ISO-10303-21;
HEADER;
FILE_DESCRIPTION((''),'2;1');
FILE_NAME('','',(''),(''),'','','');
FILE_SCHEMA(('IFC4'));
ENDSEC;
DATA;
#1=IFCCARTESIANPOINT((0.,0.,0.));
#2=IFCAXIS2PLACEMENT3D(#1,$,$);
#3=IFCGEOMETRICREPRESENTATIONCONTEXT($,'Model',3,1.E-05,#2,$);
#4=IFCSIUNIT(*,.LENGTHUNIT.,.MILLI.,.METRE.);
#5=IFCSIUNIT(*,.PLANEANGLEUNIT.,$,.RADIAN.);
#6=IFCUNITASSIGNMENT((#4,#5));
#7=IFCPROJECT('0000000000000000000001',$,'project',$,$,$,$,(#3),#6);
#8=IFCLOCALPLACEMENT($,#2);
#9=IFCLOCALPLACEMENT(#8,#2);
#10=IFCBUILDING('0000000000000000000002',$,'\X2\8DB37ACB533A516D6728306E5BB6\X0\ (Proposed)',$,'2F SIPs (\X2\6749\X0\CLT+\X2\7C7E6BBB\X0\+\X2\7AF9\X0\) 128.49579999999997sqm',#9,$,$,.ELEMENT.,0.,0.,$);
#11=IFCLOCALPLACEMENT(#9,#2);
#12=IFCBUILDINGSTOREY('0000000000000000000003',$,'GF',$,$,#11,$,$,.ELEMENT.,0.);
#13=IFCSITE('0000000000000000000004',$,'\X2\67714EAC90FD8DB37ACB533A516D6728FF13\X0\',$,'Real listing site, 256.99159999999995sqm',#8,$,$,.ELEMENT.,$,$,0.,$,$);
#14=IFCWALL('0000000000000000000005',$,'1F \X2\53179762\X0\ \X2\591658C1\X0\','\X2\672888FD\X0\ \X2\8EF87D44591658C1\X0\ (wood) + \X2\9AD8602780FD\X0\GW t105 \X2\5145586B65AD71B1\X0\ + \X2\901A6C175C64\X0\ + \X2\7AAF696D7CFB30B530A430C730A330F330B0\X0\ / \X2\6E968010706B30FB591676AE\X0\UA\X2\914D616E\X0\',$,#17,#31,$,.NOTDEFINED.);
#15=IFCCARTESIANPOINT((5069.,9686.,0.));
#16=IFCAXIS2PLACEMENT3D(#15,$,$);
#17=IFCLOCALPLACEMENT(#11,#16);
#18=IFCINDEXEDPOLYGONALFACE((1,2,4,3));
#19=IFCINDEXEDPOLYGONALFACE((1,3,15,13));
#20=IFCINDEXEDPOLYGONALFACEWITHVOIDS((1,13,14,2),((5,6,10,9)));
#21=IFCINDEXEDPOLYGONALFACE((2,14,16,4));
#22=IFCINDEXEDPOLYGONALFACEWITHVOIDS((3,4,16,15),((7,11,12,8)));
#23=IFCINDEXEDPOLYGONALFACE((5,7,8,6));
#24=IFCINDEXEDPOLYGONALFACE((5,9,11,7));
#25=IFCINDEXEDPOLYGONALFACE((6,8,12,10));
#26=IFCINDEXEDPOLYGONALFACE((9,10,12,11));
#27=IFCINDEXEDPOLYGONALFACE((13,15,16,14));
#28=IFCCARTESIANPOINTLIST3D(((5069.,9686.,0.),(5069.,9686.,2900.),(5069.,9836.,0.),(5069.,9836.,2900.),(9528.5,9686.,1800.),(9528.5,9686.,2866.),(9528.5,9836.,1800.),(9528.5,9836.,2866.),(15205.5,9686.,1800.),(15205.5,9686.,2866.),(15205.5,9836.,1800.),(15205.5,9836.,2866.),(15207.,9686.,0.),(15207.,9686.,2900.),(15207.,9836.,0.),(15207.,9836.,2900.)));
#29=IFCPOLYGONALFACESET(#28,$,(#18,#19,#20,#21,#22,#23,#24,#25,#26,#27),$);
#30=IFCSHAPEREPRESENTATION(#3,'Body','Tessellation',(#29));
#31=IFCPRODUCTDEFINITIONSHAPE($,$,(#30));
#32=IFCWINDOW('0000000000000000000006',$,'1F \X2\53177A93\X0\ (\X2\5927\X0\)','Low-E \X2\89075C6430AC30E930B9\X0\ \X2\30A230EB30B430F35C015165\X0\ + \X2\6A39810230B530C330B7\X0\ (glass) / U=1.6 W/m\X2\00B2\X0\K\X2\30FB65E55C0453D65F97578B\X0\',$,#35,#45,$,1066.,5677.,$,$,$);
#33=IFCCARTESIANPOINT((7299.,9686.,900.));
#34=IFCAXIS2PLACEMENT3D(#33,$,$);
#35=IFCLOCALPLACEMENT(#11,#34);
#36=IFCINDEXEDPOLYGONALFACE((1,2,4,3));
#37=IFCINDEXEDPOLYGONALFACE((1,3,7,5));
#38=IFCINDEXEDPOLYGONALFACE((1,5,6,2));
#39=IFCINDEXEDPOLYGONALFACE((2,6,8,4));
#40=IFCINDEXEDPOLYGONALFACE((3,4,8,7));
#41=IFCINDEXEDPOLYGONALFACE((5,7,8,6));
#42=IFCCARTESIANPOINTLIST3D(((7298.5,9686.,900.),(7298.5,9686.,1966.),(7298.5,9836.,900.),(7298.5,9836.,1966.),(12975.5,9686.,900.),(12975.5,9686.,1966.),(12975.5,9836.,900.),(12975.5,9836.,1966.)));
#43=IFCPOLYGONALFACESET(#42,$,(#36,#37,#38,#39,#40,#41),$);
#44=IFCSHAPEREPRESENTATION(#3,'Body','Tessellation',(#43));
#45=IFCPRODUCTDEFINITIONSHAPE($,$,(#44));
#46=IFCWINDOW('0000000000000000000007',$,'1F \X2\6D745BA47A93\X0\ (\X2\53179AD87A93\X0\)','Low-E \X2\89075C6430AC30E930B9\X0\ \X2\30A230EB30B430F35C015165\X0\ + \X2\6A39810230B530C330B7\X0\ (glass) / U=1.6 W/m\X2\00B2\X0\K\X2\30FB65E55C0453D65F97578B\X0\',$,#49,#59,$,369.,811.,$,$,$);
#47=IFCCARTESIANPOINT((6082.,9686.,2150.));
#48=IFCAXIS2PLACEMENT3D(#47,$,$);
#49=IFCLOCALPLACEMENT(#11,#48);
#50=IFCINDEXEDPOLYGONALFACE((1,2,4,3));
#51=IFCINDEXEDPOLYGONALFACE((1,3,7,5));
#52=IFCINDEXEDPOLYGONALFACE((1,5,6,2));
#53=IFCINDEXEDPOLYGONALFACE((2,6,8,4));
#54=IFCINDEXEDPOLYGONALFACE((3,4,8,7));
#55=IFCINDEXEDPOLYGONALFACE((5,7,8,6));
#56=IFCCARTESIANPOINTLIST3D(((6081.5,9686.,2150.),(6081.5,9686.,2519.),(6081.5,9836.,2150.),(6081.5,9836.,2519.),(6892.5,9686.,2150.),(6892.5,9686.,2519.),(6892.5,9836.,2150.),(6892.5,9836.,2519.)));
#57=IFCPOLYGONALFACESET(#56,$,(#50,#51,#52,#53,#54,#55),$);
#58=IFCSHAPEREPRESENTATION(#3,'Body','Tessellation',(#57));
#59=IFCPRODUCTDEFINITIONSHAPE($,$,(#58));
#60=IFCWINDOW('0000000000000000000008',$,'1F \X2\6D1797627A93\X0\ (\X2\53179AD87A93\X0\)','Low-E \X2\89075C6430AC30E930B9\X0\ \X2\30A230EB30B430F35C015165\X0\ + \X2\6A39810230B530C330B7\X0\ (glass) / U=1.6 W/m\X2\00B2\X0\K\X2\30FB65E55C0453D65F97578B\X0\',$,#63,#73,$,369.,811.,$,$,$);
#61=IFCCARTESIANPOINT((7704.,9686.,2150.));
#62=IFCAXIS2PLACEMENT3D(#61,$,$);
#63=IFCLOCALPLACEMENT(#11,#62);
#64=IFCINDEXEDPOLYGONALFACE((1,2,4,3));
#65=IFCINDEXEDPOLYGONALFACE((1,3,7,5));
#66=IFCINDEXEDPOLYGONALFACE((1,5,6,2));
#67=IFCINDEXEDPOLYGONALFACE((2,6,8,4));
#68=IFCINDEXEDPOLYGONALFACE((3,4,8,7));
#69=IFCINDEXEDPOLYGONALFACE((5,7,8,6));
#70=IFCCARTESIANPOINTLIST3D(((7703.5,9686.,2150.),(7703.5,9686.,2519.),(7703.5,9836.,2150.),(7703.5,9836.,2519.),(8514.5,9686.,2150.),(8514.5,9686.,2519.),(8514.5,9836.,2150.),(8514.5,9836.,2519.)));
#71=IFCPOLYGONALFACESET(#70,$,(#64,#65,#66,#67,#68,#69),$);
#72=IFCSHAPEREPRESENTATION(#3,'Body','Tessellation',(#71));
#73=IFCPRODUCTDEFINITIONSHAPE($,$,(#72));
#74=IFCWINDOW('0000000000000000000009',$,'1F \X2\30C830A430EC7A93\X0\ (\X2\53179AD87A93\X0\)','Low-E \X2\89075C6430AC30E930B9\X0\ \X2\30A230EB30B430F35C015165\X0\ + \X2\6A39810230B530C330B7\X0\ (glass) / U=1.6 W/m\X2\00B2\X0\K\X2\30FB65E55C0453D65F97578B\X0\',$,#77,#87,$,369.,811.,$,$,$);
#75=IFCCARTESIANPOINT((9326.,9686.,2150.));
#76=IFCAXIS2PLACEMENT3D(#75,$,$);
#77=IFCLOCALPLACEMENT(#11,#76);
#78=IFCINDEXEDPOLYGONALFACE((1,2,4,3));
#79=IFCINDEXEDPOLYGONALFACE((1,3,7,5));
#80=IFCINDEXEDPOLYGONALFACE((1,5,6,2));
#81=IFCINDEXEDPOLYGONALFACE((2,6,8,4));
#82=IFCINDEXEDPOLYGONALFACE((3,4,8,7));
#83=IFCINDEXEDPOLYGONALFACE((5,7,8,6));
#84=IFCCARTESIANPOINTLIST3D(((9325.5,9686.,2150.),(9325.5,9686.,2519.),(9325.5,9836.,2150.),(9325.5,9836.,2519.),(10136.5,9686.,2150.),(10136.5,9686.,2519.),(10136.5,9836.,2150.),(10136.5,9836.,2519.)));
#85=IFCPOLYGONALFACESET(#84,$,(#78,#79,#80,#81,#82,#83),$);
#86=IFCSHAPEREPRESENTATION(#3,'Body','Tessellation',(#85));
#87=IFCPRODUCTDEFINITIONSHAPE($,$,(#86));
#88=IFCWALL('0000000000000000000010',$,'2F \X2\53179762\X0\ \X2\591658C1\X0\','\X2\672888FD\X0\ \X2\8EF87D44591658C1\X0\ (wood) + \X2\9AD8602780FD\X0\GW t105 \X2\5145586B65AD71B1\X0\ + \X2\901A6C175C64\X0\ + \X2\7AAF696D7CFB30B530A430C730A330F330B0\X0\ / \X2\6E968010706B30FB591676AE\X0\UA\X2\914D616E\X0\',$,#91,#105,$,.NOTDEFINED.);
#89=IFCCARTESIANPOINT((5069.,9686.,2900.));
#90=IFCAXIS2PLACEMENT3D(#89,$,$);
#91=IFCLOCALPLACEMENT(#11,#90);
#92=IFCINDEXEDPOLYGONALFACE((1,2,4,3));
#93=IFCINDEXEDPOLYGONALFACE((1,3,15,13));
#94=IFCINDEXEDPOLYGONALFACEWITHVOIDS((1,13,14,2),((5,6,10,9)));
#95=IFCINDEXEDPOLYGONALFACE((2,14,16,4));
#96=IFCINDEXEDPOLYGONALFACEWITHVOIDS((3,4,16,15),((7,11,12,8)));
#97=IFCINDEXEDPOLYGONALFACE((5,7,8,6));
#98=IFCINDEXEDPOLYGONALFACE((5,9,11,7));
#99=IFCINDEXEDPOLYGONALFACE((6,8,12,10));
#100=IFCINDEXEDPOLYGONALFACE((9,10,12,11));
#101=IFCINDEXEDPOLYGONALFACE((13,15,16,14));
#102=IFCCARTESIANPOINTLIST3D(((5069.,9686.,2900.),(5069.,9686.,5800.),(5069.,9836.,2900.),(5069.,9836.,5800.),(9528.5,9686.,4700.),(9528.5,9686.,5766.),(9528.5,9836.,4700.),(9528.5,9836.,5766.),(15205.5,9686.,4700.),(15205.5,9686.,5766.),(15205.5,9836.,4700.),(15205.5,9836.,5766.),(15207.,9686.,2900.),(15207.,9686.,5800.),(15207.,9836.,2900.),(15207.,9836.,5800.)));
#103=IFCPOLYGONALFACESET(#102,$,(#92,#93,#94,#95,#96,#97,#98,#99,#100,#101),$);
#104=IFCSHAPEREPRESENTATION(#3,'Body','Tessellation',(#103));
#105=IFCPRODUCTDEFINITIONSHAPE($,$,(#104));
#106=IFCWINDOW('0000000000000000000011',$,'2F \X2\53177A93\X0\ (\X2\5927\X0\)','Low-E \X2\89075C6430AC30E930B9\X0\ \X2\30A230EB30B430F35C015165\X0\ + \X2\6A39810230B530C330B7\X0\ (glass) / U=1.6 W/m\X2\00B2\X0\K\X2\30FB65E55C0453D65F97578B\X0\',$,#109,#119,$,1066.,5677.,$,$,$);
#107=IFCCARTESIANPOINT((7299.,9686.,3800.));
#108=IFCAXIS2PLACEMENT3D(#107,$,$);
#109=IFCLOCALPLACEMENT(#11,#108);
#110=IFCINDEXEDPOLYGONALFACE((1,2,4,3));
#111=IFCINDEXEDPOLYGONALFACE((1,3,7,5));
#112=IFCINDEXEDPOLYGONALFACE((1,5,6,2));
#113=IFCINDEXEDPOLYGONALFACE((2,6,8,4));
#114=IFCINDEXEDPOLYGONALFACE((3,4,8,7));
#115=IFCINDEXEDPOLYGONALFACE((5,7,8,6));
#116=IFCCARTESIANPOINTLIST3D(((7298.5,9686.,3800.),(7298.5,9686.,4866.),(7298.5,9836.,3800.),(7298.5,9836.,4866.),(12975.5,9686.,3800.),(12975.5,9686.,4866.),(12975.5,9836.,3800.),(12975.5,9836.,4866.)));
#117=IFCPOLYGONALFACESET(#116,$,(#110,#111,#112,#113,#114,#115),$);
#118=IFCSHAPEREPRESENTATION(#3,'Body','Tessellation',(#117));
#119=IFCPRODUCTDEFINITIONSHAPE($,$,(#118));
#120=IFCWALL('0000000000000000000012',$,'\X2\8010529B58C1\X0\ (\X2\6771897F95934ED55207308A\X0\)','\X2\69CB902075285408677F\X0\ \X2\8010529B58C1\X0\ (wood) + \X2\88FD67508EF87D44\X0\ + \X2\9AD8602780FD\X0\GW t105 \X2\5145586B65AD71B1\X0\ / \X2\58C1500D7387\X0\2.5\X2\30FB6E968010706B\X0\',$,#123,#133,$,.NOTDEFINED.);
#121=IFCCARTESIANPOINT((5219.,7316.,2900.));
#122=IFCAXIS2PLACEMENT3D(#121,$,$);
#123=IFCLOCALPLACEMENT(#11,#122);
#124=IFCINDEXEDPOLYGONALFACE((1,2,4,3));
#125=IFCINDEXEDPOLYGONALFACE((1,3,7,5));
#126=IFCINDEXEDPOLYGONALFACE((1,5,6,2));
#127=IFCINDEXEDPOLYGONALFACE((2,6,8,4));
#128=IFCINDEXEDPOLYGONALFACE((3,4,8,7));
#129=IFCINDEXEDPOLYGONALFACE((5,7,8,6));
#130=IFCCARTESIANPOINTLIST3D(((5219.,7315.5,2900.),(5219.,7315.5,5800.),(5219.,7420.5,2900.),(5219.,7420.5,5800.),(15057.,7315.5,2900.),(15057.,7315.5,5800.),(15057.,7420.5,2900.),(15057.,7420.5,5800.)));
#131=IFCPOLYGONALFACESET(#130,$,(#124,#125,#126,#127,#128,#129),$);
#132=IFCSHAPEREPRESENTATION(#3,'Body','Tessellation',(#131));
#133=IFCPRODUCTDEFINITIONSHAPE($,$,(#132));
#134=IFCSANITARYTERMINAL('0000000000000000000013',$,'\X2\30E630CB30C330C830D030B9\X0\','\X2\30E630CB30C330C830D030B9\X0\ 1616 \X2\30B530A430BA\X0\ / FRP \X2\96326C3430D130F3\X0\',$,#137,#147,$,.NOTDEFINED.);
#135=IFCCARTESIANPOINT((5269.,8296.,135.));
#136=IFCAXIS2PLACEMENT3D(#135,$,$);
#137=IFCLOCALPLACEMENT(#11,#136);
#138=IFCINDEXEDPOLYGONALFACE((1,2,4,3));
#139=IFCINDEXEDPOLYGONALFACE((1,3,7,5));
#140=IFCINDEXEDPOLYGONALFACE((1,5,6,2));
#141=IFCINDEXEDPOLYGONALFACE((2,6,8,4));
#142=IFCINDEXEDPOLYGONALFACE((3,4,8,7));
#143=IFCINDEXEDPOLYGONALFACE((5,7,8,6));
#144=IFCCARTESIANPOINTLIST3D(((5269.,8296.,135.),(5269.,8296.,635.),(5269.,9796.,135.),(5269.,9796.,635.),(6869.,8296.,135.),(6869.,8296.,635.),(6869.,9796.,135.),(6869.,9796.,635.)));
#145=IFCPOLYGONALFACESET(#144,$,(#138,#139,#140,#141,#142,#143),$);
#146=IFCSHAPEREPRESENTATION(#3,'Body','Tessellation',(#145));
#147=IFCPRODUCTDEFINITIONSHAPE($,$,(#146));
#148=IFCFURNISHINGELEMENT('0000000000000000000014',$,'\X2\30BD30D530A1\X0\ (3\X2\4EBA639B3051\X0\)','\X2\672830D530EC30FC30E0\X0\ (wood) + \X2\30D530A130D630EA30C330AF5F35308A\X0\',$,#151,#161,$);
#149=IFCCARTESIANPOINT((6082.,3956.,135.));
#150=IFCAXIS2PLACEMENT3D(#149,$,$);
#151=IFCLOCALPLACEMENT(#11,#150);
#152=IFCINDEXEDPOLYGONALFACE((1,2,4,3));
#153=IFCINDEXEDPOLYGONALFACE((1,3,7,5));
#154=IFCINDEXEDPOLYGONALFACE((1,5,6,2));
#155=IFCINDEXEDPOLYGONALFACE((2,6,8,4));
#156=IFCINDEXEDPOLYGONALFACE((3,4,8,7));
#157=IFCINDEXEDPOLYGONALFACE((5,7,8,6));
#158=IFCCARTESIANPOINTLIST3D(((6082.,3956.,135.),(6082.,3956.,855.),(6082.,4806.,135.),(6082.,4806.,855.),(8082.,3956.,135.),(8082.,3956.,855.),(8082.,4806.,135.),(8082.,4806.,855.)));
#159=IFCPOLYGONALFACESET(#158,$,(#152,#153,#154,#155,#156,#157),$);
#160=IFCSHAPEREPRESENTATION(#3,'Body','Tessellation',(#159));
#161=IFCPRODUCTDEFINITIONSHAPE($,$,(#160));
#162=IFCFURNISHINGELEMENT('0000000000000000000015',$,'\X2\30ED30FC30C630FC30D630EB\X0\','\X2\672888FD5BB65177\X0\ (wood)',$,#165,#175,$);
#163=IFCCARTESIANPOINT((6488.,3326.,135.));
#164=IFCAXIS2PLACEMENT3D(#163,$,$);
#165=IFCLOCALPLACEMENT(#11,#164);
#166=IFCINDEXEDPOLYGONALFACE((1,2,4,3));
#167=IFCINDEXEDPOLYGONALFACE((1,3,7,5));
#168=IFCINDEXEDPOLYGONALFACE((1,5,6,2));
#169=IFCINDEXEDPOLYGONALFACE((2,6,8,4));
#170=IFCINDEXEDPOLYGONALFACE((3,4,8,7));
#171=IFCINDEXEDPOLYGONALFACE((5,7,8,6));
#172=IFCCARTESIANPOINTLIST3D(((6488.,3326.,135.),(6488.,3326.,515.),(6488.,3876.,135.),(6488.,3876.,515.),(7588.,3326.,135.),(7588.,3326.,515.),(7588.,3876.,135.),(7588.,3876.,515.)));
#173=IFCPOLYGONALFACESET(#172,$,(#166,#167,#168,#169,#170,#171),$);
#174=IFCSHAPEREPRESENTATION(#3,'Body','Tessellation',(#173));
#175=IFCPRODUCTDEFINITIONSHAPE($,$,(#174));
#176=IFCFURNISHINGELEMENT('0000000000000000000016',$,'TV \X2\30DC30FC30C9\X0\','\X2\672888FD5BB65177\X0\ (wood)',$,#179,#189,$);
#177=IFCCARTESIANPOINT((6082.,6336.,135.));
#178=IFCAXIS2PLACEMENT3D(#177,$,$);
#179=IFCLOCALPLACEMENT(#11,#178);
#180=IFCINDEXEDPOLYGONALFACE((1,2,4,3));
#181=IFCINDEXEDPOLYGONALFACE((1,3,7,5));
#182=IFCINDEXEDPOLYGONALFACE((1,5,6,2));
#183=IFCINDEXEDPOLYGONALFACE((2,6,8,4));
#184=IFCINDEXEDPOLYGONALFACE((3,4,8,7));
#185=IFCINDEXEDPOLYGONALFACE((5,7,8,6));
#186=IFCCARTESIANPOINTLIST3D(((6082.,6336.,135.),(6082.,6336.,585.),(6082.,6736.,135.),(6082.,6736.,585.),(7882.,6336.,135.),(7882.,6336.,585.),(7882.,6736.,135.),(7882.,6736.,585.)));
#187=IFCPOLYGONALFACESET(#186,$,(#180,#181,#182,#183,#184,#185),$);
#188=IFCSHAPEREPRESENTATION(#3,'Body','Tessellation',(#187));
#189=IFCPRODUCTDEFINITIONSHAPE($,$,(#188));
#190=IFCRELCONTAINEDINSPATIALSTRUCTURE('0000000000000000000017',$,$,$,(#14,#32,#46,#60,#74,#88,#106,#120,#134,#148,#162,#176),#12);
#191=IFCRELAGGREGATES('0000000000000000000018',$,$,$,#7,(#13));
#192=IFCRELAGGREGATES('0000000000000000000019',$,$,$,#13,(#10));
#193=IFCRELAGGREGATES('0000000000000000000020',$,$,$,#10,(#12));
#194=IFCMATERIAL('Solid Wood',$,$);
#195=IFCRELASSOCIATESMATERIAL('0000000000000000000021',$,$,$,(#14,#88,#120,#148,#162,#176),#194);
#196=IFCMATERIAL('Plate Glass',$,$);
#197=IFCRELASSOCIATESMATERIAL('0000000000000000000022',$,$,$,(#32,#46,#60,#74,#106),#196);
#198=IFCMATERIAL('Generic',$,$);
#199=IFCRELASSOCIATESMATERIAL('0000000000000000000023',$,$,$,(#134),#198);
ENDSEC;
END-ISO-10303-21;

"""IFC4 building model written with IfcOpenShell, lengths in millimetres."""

from ifc_helpers import new_model, si_unit, frame, frame_2d, origin, place, context, project, spatial, rectangle, extrude, material, element, fill, save


model = new_model("IFC4")

# Units and contexts
model_context = context("Model", 3, precision=1e-05, world=origin())
ifc_project = project(units=[si_unit("LENGTHUNIT", "METRE", prefix="MILLI"), si_unit("PLANEANGLEUNIT", "RADIAN")], contexts=[model_context])

# Site, building, storey
site_placement = place(None, origin())
site = spatial("IfcSite", under=ifc_project, at=site_placement, Name="東京都足立区六木３", ObjectType="Real listing site, 256.99159999999995sqm", CompositionType="ELEMENT", RefElevation=0.0)
building_placement = place(site_placement, origin())
building = spatial("IfcBuilding", under=site, at=building_placement, Name="足立区六木の家 (Proposed)", ObjectType="2F SIPs (杉CLT+籾殻+竹) 128.49579999999997sqm", CompositionType="ELEMENT", ElevationOfRefHeight=0.0, ElevationOfTerrain=0.0)
storey_placement = place(building_placement, origin())
storey = spatial("IfcBuildingStorey", under=building, at=storey_placement, Name="GF", CompositionType="ELEMENT", Elevation=0.0)

# Wall, openings, windows
ifc_material_1 = material(Name="Solid Wood")
wall_1_placement = place(storey_placement, frame((5069.0, 9686.0, 0.0)))
wall_1 = element("IfcWall", 1, at=wall_1_placement, inside=storey, material=ifc_material_1, Name="1F 北面 外壁", Description="木製 軸組外壁 (wood) + 高性能GW t105 充填断熱 + 通気層 + 窯業系サイディング / 準耐火・外皮UA配慮", PredefinedType="NOTDEFINED", context=model_context, shape_type="SweptSolid", body=[
    extrude(rectangle(XDim=10138.0, YDim=150.0, at=frame_2d((5069.0, 75.0))), frame((5069.0, 9686.0, 0.0)), (0.0, 0.0, 1.0), 2900.0),
])
opening_1_placement = place(storey_placement, frame((7299.0, 9686.0, 900.0)))
opening_1 = element("IfcOpeningElement", 2, at=opening_1_placement, cuts=wall_1, PredefinedType="NOTDEFINED", context=model_context, shape_type="SweptSolid", body=[
    extrude(rectangle(XDim=5677.0, YDim=150.0, at=frame_2d((2838.0, 75.0))), frame((7299.0, 9686.0, 900.0)), (0.0, 0.0, 1.0), 1066.0),
])
opening_2_placement = place(storey_placement, frame((6082.0, 9686.0, 2150.0)))
opening_2 = element("IfcOpeningElement", 3, at=opening_2_placement, cuts=wall_1, PredefinedType="NOTDEFINED", context=model_context, shape_type="SweptSolid", body=[
    extrude(rectangle(XDim=811.0, YDim=150.0, at=frame_2d((405.0, 75.0))), frame((6082.0, 9686.0, 2150.0)), (0.0, 0.0, 1.0), 369.0),
])
opening_3_placement = place(storey_placement, frame((7704.0, 9686.0, 2150.0)))
opening_3 = element("IfcOpeningElement", 4, at=opening_3_placement, cuts=wall_1, PredefinedType="NOTDEFINED", context=model_context, shape_type="SweptSolid", body=[
    extrude(rectangle(XDim=811.0, YDim=150.0, at=frame_2d((405.0, 75.0))), frame((7704.0, 9686.0, 2150.0)), (0.0, 0.0, 1.0), 369.0),
])
opening_4_placement = place(storey_placement, frame((9326.0, 9686.0, 2150.0)))
opening_4 = element("IfcOpeningElement", 5, at=opening_4_placement, cuts=wall_1, PredefinedType="NOTDEFINED", context=model_context, shape_type="SweptSolid", body=[
    extrude(rectangle(XDim=811.0, YDim=150.0, at=frame_2d((405.0, 75.0))), frame((9326.0, 9686.0, 2150.0)), (0.0, 0.0, 1.0), 369.0),
])
ifc_material_2 = material(Name="Plate Glass")
window_1_placement = place(storey_placement, frame((7299.0, 9686.0, 900.0)))
window_1 = element("IfcWindow", 6, at=window_1_placement, inside=storey, material=ifc_material_2, Name="1F 北窓 (大)", Description="Low-E 複層ガラス アルゴン封入 + 樹脂サッシ (glass) / U=1.6 W/m²K・日射取得型", OverallHeight=1066.0, OverallWidth=5677.0, context=model_context, shape_type="SweptSolid", body=[
    extrude(rectangle(XDim=5677.0, YDim=150.0, at=frame_2d((2838.0, 75.0))), frame((7299.0, 9686.0, 900.0)), (0.0, 0.0, 1.0), 1066.0),
])
fill(opening_1, window_1)
window_2_placement = place(storey_placement, frame((6082.0, 9686.0, 2150.0)))
window_2 = element("IfcWindow", 7, at=window_2_placement, inside=storey, material=ifc_material_2, Name="1F 浴室窓 (北高窓)", Description="Low-E 複層ガラス アルゴン封入 + 樹脂サッシ (glass) / U=1.6 W/m²K・日射取得型", OverallHeight=369.0, OverallWidth=811.0, context=model_context, shape_type="SweptSolid", body=[
    extrude(rectangle(XDim=811.0, YDim=150.0, at=frame_2d((405.0, 75.0))), frame((6082.0, 9686.0, 2150.0)), (0.0, 0.0, 1.0), 369.0),
])
fill(opening_2, window_2)
window_3_placement = place(storey_placement, frame((7704.0, 9686.0, 2150.0)))
window_3 = element("IfcWindow", 8, at=window_3_placement, inside=storey, material=ifc_material_2, Name="1F 洗面窓 (北高窓)", Description="Low-E 複層ガラス アルゴン封入 + 樹脂サッシ (glass) / U=1.6 W/m²K・日射取得型", OverallHeight=369.0, OverallWidth=811.0, context=model_context, shape_type="SweptSolid", body=[
    extrude(rectangle(XDim=811.0, YDim=150.0, at=frame_2d((405.0, 75.0))), frame((7704.0, 9686.0, 2150.0)), (0.0, 0.0, 1.0), 369.0),
])
fill(opening_3, window_3)
window_4_placement = place(storey_placement, frame((9326.0, 9686.0, 2150.0)))
window_4 = element("IfcWindow", 9, at=window_4_placement, inside=storey, material=ifc_material_2, Name="1F トイレ窓 (北高窓)", Description="Low-E 複層ガラス アルゴン封入 + 樹脂サッシ (glass) / U=1.6 W/m²K・日射取得型", OverallHeight=369.0, OverallWidth=811.0, context=model_context, shape_type="SweptSolid", body=[
    extrude(rectangle(XDim=811.0, YDim=150.0, at=frame_2d((405.0, 75.0))), frame((9326.0, 9686.0, 2150.0)), (0.0, 0.0, 1.0), 369.0),
])
fill(opening_4, window_4)

# Wall, opening, window
wall_2_placement = place(storey_placement, frame((5069.0, 9686.0, 2900.0)))
wall_2 = element("IfcWall", 10, at=wall_2_placement, inside=storey, material=ifc_material_1, Name="2F 北面 外壁", Description="木製 軸組外壁 (wood) + 高性能GW t105 充填断熱 + 通気層 + 窯業系サイディング / 準耐火・外皮UA配慮", PredefinedType="NOTDEFINED", context=model_context, shape_type="SweptSolid", body=[
    extrude(rectangle(XDim=10138.0, YDim=150.0, at=frame_2d((5069.0, 75.0))), frame((5069.0, 9686.0, 2900.0)), (0.0, 0.0, 1.0), 2900.0),
])
opening_5_placement = place(storey_placement, frame((7299.0, 9686.0, 3800.0)))
opening_5 = element("IfcOpeningElement", 11, at=opening_5_placement, cuts=wall_2, PredefinedType="NOTDEFINED", context=model_context, shape_type="SweptSolid", body=[
    extrude(rectangle(XDim=5677.0, YDim=150.0, at=frame_2d((2838.0, 75.0))), frame((7299.0, 9686.0, 3800.0)), (0.0, 0.0, 1.0), 1066.0),
])
window_5_placement = place(storey_placement, frame((7299.0, 9686.0, 3800.0)))
window_5 = element("IfcWindow", 12, at=window_5_placement, inside=storey, material=ifc_material_2, Name="2F 北窓 (大)", Description="Low-E 複層ガラス アルゴン封入 + 樹脂サッシ (glass) / U=1.6 W/m²K・日射取得型", OverallHeight=1066.0, OverallWidth=5677.0, context=model_context, shape_type="SweptSolid", body=[
    extrude(rectangle(XDim=5677.0, YDim=150.0, at=frame_2d((2838.0, 75.0))), frame((7299.0, 9686.0, 3800.0)), (0.0, 0.0, 1.0), 1066.0),
])
fill(opening_5, window_5)

# Wall
wall_3_placement = place(storey_placement, frame((5219.0, 7316.0, 2900.0)))
element("IfcWall", 13, at=wall_3_placement, inside=storey, material=ifc_material_1, Name="耐力壁 (東西間仕切り)", Description="構造用合板 耐力壁 (wood) + 製材軸組 + 高性能GW t105 充填断熱 / 壁倍率2.5・準耐火", PredefinedType="NOTDEFINED", context=model_context, shape_type="SweptSolid", body=[
    extrude(rectangle(XDim=9838.0, YDim=105.0, at=frame_2d((4919.0, 52.0))), frame((5219.0, 7316.0, 2900.0)), (0.0, 0.0, 1.0), 2900.0),
])

# Sanitary terminal
ifc_material_3 = material(Name="Generic")
sanitary_terminal_placement = place(storey_placement, frame((5269.0, 8296.0, 135.0)))
element("IfcSanitaryTerminal", 14, at=sanitary_terminal_placement, inside=storey, material=ifc_material_3, Name="ユニットバス", Description="ユニットバス 1616 サイズ / FRP 防水パン", PredefinedType="NOTDEFINED", context=model_context, shape_type="SweptSolid", body=[
    extrude(rectangle(XDim=1600.0, YDim=1500.0, at=frame_2d((800.0, 750.0))), frame((5269.0, 8296.0, 135.0)), (0.0, 0.0, 1.0), 500.0),
])

# Furnishing elements
furnishing_1_placement = place(storey_placement, frame((6082.0, 3956.0, 135.0)))
element("IfcFurnishingElement", 15, at=furnishing_1_placement, inside=storey, material=ifc_material_1, Name="ソファ (3人掛け)", Description="木フレーム (wood) + ファブリック張り", context=model_context, shape_type="SweptSolid", body=[
    extrude(rectangle(XDim=2000.0, YDim=850.0, at=frame_2d((1000.0, 425.0))), frame((6082.0, 3956.0, 135.0)), (0.0, 0.0, 1.0), 720.0),
])
furnishing_2_placement = place(storey_placement, frame((6488.0, 3326.0, 135.0)))
element("IfcFurnishingElement", 16, at=furnishing_2_placement, inside=storey, material=ifc_material_1, Name="ローテーブル", Description="木製家具 (wood)", context=model_context, shape_type="SweptSolid", body=[
    extrude(rectangle(XDim=1100.0, YDim=550.0, at=frame_2d((550.0, 275.0))), frame((6488.0, 3326.0, 135.0)), (0.0, 0.0, 1.0), 380.0),
])
furnishing_3_placement = place(storey_placement, frame((6082.0, 6336.0, 135.0)))
element("IfcFurnishingElement", 17, at=furnishing_3_placement, inside=storey, material=ifc_material_1, Name="TV ボード", Description="木製家具 (wood)", context=model_context, shape_type="SweptSolid", body=[
    extrude(rectangle(XDim=1800.0, YDim=400.0, at=frame_2d((900.0, 200.0))), frame((6082.0, 6336.0, 135.0)), (0.0, 0.0, 1.0), 450.0),
])

save(model, "model.ifc")
